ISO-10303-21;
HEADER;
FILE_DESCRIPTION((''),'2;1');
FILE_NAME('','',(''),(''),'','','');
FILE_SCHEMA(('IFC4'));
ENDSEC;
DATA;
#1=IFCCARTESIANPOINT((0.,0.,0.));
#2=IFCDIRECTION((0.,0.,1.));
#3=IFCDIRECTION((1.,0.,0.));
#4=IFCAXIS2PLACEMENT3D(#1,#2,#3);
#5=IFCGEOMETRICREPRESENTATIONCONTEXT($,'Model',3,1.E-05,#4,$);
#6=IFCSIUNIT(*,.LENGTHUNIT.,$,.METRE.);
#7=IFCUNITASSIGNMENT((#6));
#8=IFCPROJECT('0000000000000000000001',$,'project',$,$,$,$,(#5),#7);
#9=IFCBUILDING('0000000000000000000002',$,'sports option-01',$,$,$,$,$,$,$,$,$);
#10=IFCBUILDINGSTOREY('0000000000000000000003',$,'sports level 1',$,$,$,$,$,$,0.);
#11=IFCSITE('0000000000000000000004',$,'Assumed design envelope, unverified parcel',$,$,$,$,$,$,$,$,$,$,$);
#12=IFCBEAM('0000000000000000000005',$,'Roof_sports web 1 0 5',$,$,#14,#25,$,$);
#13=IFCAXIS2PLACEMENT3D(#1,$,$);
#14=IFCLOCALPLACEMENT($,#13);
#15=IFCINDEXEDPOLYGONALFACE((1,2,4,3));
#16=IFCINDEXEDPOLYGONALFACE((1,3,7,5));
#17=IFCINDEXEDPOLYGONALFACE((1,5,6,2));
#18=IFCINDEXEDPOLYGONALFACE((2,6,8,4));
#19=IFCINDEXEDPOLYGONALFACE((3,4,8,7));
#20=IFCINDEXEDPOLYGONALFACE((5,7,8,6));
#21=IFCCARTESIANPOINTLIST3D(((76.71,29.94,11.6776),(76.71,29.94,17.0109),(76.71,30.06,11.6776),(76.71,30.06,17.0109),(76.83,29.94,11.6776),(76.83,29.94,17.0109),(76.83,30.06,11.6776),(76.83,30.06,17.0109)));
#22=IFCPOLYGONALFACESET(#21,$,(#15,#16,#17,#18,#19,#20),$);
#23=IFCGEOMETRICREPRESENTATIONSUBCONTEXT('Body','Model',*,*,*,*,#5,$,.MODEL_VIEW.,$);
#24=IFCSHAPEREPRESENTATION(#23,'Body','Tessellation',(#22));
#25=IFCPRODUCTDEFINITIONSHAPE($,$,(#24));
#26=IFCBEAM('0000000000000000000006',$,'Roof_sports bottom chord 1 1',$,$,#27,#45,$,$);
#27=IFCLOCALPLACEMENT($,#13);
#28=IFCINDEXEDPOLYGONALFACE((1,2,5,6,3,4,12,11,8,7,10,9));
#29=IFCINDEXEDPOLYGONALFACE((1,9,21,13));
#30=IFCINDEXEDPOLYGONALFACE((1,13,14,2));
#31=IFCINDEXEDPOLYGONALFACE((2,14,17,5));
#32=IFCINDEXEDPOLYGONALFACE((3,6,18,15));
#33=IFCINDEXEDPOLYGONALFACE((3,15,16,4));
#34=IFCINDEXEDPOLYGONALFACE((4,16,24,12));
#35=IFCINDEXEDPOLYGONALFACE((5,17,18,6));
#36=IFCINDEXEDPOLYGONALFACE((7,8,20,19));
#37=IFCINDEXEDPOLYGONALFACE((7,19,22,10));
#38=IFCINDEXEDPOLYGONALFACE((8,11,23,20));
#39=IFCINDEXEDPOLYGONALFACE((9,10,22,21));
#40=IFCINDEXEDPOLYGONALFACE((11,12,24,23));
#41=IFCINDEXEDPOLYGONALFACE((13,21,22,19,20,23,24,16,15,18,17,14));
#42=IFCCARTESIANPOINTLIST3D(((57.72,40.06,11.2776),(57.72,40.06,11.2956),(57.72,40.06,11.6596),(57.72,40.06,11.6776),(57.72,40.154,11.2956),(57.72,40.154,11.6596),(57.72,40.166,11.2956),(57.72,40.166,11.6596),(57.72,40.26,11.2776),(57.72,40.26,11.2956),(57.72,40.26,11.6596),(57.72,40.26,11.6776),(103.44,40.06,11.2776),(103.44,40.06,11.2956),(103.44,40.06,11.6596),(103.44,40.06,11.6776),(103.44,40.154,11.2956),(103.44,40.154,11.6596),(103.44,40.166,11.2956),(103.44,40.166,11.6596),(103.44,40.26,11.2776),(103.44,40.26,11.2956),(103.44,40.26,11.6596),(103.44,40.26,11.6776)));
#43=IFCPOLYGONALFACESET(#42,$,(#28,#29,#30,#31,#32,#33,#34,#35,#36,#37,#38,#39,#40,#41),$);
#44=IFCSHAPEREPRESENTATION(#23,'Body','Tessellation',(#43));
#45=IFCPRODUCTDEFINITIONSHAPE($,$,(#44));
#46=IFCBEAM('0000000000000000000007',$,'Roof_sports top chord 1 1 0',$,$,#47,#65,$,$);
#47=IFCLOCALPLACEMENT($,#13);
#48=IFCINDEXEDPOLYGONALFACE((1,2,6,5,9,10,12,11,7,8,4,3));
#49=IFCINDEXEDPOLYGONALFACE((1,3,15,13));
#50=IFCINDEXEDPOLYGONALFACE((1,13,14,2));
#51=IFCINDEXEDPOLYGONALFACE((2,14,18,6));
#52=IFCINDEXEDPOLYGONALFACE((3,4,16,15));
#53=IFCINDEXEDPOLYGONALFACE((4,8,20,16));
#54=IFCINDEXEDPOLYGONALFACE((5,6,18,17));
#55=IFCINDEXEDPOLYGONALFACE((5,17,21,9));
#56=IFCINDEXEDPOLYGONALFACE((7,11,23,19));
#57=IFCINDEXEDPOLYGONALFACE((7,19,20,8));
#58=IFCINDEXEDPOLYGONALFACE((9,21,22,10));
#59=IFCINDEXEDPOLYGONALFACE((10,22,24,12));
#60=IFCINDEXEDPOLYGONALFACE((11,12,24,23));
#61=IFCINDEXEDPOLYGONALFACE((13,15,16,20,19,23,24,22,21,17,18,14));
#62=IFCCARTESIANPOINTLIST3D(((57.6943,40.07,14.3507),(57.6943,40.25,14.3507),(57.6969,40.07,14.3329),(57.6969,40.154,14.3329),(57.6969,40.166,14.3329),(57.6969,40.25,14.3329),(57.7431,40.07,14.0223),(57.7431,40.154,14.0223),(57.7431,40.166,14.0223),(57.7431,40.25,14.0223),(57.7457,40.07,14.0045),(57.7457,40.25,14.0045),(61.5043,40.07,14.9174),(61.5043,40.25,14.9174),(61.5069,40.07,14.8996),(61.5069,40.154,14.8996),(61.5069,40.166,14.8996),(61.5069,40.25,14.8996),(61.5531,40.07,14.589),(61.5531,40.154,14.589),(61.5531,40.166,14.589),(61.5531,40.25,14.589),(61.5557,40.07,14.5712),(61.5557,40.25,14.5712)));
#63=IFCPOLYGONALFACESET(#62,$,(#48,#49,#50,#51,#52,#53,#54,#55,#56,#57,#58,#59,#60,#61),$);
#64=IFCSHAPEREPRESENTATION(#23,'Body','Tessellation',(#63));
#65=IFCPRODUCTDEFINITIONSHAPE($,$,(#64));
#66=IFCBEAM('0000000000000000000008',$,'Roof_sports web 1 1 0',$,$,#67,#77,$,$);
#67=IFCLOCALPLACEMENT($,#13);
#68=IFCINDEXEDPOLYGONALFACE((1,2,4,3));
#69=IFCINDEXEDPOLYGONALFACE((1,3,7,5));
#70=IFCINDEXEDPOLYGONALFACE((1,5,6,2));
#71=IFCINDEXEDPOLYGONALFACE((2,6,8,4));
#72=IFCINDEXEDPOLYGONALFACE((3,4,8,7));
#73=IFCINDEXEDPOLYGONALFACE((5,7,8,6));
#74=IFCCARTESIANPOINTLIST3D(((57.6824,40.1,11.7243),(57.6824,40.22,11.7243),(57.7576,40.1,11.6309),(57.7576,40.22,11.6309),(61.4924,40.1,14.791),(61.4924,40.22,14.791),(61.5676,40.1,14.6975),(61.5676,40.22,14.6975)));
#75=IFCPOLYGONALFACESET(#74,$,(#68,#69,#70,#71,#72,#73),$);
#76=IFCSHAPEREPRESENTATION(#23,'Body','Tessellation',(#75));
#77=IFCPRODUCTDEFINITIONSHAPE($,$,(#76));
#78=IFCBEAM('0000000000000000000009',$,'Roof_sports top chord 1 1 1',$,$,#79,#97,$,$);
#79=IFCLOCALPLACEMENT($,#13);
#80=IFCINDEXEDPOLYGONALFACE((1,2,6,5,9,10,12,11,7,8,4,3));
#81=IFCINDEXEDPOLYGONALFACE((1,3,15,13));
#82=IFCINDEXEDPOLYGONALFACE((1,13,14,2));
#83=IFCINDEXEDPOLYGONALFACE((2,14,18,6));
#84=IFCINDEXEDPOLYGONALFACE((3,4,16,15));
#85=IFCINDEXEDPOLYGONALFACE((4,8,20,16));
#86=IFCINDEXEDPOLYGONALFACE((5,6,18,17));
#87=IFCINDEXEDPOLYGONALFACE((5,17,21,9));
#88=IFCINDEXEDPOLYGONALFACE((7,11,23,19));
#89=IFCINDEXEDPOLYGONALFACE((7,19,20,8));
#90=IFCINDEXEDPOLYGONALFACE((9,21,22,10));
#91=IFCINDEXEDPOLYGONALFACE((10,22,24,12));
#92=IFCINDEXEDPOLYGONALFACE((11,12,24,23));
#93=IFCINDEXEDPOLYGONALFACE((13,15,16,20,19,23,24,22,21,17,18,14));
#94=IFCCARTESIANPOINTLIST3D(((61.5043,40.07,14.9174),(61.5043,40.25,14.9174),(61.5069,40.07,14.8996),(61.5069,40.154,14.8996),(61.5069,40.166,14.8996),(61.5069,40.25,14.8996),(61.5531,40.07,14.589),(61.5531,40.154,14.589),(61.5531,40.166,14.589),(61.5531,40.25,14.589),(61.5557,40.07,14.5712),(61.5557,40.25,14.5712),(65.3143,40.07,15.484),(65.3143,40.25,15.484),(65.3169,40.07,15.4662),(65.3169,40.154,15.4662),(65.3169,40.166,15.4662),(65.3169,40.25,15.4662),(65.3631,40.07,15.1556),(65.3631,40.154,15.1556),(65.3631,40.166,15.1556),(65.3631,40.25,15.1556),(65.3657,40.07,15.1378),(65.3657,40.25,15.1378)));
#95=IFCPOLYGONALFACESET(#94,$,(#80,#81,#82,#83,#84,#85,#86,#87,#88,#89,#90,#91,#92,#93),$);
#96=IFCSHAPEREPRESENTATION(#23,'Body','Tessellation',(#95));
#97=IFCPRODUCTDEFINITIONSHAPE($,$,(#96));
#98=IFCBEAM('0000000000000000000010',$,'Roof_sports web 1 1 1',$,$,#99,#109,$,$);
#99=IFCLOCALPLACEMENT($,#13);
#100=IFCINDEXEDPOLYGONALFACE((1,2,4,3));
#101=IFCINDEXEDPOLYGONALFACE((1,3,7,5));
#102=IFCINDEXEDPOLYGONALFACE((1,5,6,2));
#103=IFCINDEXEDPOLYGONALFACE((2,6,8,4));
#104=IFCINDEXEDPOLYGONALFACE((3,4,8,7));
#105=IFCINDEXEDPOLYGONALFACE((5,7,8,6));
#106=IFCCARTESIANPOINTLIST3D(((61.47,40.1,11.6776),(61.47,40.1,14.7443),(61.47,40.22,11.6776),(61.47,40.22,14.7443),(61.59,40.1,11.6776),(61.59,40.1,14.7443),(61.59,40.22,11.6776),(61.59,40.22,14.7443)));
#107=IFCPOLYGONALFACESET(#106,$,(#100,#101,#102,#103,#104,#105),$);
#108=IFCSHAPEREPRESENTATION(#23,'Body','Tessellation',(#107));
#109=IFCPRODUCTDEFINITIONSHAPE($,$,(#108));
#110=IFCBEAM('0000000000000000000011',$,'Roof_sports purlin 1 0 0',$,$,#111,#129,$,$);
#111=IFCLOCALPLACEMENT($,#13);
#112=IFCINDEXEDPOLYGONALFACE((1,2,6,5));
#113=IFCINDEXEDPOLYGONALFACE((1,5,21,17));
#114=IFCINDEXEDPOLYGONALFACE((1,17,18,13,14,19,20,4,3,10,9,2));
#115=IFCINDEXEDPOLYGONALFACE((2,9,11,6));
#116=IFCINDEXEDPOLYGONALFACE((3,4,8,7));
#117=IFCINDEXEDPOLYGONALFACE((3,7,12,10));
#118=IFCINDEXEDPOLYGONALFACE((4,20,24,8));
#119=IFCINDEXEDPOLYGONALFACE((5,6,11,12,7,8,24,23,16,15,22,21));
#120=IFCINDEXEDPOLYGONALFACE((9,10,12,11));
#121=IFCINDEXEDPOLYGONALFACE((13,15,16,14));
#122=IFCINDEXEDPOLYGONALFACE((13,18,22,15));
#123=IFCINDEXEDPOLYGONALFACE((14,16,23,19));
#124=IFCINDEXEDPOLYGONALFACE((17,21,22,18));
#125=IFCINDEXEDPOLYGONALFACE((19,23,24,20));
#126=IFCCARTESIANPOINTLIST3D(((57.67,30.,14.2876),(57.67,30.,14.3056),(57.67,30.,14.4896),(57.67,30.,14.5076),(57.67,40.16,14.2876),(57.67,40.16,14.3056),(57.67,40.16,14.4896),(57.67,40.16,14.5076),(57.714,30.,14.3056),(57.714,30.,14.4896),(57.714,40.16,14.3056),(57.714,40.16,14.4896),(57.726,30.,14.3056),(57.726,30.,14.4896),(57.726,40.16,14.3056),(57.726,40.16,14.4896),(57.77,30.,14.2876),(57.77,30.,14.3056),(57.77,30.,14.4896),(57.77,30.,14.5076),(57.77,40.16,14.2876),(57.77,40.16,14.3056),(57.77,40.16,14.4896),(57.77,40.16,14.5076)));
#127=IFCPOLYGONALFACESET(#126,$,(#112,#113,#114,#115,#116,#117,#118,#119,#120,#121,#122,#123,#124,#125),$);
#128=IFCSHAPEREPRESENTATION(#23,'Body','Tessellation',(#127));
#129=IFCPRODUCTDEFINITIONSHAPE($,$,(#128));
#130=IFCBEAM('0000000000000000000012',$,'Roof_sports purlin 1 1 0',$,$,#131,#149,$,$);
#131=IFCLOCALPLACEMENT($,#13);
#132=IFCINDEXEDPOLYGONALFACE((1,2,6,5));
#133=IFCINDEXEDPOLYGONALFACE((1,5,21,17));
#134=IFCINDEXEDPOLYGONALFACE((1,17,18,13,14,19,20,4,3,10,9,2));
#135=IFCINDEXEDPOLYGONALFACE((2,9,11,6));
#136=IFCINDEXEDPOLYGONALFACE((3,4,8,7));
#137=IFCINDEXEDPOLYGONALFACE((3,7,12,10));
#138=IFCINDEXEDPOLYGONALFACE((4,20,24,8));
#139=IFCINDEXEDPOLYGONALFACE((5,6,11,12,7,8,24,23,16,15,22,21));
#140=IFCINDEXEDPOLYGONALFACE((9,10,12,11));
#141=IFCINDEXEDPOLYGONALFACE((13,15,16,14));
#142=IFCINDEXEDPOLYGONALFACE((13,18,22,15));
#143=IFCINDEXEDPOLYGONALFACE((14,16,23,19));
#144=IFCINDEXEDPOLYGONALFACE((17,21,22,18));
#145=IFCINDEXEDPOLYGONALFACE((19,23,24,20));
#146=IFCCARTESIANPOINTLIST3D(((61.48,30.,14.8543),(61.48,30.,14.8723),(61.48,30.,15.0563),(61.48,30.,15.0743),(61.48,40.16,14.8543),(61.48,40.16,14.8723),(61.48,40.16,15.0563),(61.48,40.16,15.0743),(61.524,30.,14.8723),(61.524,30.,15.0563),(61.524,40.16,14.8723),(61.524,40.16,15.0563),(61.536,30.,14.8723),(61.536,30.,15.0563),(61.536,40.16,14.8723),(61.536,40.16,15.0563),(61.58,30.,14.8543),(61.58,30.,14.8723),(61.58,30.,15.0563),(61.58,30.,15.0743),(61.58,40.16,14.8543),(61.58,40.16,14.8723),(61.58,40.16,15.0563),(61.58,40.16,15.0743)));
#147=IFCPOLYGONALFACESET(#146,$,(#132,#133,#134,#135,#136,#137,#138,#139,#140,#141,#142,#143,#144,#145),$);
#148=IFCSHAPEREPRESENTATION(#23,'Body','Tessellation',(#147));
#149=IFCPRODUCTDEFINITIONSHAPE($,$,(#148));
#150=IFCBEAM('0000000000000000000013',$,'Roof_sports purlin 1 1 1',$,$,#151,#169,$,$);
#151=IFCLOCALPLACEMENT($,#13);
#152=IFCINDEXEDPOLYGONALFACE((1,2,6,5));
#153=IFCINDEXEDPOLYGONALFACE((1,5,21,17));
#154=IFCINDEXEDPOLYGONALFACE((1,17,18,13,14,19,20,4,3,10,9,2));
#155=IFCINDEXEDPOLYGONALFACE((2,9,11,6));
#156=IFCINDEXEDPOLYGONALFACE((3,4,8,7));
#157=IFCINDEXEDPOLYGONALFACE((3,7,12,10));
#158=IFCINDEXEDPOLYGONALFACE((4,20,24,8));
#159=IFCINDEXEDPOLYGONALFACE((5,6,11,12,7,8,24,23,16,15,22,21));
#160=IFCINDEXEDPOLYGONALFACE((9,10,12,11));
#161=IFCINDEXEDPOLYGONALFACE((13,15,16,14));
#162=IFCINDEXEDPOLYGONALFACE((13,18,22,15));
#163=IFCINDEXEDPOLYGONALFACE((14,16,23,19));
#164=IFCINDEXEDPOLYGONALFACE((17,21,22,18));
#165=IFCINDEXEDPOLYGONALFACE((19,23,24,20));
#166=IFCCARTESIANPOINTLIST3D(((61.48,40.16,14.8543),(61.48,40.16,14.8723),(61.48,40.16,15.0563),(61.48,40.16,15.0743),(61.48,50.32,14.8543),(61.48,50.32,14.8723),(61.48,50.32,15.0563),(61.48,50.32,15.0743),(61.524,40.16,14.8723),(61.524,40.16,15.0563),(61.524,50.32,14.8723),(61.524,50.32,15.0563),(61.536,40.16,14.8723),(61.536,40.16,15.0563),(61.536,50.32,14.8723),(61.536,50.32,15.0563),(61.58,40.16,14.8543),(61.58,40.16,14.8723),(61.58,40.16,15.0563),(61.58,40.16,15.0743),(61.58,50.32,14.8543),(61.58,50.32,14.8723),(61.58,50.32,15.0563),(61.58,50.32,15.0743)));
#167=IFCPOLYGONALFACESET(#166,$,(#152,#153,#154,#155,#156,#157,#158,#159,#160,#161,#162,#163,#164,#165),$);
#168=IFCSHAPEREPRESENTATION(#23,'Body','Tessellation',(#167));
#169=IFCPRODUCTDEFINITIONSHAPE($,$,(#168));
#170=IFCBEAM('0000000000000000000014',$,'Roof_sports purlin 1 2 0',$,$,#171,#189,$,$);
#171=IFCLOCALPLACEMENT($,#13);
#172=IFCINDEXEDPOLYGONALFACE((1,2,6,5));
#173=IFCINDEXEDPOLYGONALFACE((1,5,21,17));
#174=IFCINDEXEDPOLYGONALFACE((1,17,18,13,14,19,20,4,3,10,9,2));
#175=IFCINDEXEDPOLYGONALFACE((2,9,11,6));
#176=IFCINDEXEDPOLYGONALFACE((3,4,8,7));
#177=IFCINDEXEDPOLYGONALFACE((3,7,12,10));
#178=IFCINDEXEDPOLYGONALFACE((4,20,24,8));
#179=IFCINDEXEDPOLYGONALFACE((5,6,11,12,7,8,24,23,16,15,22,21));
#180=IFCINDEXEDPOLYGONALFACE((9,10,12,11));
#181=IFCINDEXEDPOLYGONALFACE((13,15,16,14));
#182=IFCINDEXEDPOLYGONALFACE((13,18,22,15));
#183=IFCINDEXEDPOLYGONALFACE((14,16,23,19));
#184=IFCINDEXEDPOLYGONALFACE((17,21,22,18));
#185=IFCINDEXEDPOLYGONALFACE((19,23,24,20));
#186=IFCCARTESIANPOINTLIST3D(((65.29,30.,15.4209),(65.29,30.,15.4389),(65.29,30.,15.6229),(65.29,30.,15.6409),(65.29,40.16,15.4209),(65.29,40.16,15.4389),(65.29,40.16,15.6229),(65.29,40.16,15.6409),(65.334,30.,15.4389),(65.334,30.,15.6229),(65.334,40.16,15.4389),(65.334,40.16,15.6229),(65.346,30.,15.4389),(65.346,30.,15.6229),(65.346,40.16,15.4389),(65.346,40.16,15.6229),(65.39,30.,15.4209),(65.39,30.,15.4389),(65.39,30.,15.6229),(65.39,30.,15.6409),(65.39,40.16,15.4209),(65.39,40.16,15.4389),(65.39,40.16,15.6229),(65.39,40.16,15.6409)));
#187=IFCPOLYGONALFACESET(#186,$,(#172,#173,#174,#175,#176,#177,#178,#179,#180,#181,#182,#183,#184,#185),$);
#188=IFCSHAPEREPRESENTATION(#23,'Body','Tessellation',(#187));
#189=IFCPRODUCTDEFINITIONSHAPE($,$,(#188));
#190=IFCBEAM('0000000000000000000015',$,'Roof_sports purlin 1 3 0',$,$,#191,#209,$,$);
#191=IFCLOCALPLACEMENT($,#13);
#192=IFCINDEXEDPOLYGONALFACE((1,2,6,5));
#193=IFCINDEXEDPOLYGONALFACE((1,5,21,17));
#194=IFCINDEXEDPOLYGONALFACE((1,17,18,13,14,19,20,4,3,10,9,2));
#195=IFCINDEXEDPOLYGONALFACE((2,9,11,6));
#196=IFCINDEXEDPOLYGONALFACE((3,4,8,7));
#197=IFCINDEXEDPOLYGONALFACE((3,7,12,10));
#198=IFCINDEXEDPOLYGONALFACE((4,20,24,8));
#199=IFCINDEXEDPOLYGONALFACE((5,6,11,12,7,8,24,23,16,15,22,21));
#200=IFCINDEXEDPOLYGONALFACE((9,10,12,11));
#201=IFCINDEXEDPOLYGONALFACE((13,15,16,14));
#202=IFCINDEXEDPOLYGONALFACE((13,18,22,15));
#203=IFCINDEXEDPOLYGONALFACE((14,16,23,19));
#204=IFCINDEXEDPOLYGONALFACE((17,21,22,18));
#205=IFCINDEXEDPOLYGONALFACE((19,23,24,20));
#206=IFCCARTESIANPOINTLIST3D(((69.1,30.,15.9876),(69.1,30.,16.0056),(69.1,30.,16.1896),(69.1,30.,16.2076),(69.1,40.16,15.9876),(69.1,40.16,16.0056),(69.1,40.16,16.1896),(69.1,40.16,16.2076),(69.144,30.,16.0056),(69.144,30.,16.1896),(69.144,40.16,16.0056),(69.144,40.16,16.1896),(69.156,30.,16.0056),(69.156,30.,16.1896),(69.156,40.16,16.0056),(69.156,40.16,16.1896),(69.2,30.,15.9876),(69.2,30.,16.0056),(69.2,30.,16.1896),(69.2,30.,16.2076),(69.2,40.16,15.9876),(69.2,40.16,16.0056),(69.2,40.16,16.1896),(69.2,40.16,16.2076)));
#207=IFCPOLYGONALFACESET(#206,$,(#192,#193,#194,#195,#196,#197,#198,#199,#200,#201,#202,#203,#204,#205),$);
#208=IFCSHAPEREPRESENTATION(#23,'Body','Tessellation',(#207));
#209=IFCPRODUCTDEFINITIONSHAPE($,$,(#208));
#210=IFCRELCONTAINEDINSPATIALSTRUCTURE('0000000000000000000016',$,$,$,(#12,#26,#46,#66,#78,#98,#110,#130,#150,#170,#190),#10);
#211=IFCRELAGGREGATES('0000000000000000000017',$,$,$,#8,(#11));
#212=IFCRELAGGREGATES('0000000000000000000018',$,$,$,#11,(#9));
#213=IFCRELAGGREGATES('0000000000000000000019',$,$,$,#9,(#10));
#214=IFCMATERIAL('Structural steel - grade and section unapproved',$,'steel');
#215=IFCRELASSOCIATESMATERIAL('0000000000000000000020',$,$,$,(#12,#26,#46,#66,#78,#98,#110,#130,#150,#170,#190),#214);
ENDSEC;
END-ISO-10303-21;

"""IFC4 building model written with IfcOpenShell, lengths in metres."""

from ifc_helpers import new_model, si_unit, frame, origin_with_axes, place, context, subcontext, project, spatial, rectangle, i_section, extrude, material, element, save


model = new_model("IFC4")

# Units and contexts
model_context = context("Model", 3, precision=1e-05, world=origin_with_axes())
body_context = subcontext(model_context, "Body", "Model", "MODEL_VIEW")
ifc_project = project(units=[si_unit("LENGTHUNIT", "METRE")], contexts=[model_context])

# Site, building, storey
site = spatial("IfcSite", under=ifc_project, Name="Assumed design envelope, unverified parcel")
building = spatial("IfcBuilding", under=site, Name="sports option-01")
storey = spatial("IfcBuildingStorey", under=building, Name="sports level 1", Elevation=0.0)

# Shared definitions
ifc_material = material(Name="Structural steel - grade and section unapproved", Category="steel")

# Beams
beam_1_placement = place(None, frame((76.77, 30.0, 11.6776), z_axis=(0.0, 0.0, 1.0), x_axis=(-1.0, 0.0, 0.0)))
element("IfcBeam", 1, at=beam_1_placement, inside=storey, material=ifc_material, Name="Roof_sports web 1 0 5", context=body_context, shape_type="SweptSolid", body=[
    extrude(rectangle(XDim=0.12, YDim=0.12), origin_with_axes(), (0.0, 0.0, 1.0), 5.3333),
])
beam_2_placement = place(None, frame((57.72, 40.16, 11.4776), z_axis=(1.0, 0.0, 0.0), x_axis=(0.0, 1.0, 0.0)))
element("IfcBeam", 2, at=beam_2_placement, inside=storey, material=ifc_material, Name="Roof_sports bottom chord 1 1", context=body_context, shape_type="SweptSolid", body=[
    extrude(i_section(OverallWidth=0.2, OverallDepth=0.4, WebThickness=0.012, FlangeThickness=0.018, FilletRadius=0.0), origin_with_axes(), (0.0, 0.0, 1.0), 45.72),
])
beam_3_placement = place(None, frame((57.72, 40.16, 14.1776), z_axis=(0.98912, 0.0, 0.147113), x_axis=(0.0, 1.0, 0.0)))
element("IfcBeam", 3, at=beam_3_placement, inside=storey, material=ifc_material, Name="Roof_sports top chord 1 1 0", context=body_context, shape_type="SweptSolid", body=[
    extrude(i_section(OverallWidth=0.18, OverallDepth=0.35, WebThickness=0.012, FlangeThickness=0.018, FilletRadius=0.0), origin_with_axes(), (0.0, 0.0, 1.0), 3.8519),
])
beam_4_placement = place(None, frame((57.72, 40.16, 11.6776), z_axis=(0.779003, 0.0, 0.62702), x_axis=(0.0, 1.0, 0.0)))
element("IfcBeam", 4, at=beam_4_placement, inside=storey, material=ifc_material, Name="Roof_sports web 1 1 0", context=body_context, shape_type="SweptSolid", body=[
    extrude(rectangle(XDim=0.12, YDim=0.12), origin_with_axes(), (0.0, 0.0, 1.0), 4.8909),
])
beam_5_placement = place(None, frame((61.53, 40.16, 14.7443), z_axis=(0.98912, 0.0, 0.147113), x_axis=(0.0, 1.0, 0.0)))
element("IfcBeam", 5, at=beam_5_placement, inside=storey, material=ifc_material, Name="Roof_sports top chord 1 1 1", context=body_context, shape_type="SweptSolid", body=[
    extrude(i_section(OverallWidth=0.18, OverallDepth=0.35, WebThickness=0.012, FlangeThickness=0.018, FilletRadius=0.0), origin_with_axes(), (0.0, 0.0, 1.0), 3.8519),
])
beam_6_placement = place(None, frame((61.53, 40.16, 11.6776), z_axis=(0.0, 0.0, 1.0), x_axis=(-1.0, 0.0, 0.0)))
element("IfcBeam", 6, at=beam_6_placement, inside=storey, material=ifc_material, Name="Roof_sports web 1 1 1", context=body_context, shape_type="SweptSolid", body=[
    extrude(rectangle(XDim=0.12, YDim=0.12), origin_with_axes(), (0.0, 0.0, 1.0), 3.0667),
])
for number, where, z_axis, x_axis, name in (
    (7, (57.72, 30.0, 14.3976), (0.0, 1.0, 0.0), (-1.0, 0.0, 0.0), "Roof_sports purlin 1 0 0"),
    (8, (61.53, 30.0, 14.9643), (0.0, 1.0, 0.0), (-1.0, 0.0, 0.0), "Roof_sports purlin 1 1 0"),
    (9, (61.53, 40.16, 14.9643), (0.0, 1.0, 0.0), (-1.0, 0.0, 0.0), "Roof_sports purlin 1 1 1"),
    (10, (65.34, 30.0, 15.5309), (0.0, 1.0, 0.0), (-1.0, 0.0, 0.0), "Roof_sports purlin 1 2 0"),
    (11, (69.15, 30.0, 16.0976), (0.0, 1.0, 0.0), (-1.0, 0.0, 0.0), "Roof_sports purlin 1 3 0"),
):
    element("IfcBeam", number, at=place(None, frame(where, z_axis=z_axis, x_axis=x_axis)), inside=storey, material=ifc_material, Name=name, context=body_context, shape_type="SweptSolid", body=[
        extrude(i_section(OverallWidth=0.1, OverallDepth=0.22, WebThickness=0.012, FlangeThickness=0.018, FilletRadius=0.0), origin_with_axes(), (0.0, 0.0, 1.0), 10.16),
    ])

save(model, "model.ifc")
